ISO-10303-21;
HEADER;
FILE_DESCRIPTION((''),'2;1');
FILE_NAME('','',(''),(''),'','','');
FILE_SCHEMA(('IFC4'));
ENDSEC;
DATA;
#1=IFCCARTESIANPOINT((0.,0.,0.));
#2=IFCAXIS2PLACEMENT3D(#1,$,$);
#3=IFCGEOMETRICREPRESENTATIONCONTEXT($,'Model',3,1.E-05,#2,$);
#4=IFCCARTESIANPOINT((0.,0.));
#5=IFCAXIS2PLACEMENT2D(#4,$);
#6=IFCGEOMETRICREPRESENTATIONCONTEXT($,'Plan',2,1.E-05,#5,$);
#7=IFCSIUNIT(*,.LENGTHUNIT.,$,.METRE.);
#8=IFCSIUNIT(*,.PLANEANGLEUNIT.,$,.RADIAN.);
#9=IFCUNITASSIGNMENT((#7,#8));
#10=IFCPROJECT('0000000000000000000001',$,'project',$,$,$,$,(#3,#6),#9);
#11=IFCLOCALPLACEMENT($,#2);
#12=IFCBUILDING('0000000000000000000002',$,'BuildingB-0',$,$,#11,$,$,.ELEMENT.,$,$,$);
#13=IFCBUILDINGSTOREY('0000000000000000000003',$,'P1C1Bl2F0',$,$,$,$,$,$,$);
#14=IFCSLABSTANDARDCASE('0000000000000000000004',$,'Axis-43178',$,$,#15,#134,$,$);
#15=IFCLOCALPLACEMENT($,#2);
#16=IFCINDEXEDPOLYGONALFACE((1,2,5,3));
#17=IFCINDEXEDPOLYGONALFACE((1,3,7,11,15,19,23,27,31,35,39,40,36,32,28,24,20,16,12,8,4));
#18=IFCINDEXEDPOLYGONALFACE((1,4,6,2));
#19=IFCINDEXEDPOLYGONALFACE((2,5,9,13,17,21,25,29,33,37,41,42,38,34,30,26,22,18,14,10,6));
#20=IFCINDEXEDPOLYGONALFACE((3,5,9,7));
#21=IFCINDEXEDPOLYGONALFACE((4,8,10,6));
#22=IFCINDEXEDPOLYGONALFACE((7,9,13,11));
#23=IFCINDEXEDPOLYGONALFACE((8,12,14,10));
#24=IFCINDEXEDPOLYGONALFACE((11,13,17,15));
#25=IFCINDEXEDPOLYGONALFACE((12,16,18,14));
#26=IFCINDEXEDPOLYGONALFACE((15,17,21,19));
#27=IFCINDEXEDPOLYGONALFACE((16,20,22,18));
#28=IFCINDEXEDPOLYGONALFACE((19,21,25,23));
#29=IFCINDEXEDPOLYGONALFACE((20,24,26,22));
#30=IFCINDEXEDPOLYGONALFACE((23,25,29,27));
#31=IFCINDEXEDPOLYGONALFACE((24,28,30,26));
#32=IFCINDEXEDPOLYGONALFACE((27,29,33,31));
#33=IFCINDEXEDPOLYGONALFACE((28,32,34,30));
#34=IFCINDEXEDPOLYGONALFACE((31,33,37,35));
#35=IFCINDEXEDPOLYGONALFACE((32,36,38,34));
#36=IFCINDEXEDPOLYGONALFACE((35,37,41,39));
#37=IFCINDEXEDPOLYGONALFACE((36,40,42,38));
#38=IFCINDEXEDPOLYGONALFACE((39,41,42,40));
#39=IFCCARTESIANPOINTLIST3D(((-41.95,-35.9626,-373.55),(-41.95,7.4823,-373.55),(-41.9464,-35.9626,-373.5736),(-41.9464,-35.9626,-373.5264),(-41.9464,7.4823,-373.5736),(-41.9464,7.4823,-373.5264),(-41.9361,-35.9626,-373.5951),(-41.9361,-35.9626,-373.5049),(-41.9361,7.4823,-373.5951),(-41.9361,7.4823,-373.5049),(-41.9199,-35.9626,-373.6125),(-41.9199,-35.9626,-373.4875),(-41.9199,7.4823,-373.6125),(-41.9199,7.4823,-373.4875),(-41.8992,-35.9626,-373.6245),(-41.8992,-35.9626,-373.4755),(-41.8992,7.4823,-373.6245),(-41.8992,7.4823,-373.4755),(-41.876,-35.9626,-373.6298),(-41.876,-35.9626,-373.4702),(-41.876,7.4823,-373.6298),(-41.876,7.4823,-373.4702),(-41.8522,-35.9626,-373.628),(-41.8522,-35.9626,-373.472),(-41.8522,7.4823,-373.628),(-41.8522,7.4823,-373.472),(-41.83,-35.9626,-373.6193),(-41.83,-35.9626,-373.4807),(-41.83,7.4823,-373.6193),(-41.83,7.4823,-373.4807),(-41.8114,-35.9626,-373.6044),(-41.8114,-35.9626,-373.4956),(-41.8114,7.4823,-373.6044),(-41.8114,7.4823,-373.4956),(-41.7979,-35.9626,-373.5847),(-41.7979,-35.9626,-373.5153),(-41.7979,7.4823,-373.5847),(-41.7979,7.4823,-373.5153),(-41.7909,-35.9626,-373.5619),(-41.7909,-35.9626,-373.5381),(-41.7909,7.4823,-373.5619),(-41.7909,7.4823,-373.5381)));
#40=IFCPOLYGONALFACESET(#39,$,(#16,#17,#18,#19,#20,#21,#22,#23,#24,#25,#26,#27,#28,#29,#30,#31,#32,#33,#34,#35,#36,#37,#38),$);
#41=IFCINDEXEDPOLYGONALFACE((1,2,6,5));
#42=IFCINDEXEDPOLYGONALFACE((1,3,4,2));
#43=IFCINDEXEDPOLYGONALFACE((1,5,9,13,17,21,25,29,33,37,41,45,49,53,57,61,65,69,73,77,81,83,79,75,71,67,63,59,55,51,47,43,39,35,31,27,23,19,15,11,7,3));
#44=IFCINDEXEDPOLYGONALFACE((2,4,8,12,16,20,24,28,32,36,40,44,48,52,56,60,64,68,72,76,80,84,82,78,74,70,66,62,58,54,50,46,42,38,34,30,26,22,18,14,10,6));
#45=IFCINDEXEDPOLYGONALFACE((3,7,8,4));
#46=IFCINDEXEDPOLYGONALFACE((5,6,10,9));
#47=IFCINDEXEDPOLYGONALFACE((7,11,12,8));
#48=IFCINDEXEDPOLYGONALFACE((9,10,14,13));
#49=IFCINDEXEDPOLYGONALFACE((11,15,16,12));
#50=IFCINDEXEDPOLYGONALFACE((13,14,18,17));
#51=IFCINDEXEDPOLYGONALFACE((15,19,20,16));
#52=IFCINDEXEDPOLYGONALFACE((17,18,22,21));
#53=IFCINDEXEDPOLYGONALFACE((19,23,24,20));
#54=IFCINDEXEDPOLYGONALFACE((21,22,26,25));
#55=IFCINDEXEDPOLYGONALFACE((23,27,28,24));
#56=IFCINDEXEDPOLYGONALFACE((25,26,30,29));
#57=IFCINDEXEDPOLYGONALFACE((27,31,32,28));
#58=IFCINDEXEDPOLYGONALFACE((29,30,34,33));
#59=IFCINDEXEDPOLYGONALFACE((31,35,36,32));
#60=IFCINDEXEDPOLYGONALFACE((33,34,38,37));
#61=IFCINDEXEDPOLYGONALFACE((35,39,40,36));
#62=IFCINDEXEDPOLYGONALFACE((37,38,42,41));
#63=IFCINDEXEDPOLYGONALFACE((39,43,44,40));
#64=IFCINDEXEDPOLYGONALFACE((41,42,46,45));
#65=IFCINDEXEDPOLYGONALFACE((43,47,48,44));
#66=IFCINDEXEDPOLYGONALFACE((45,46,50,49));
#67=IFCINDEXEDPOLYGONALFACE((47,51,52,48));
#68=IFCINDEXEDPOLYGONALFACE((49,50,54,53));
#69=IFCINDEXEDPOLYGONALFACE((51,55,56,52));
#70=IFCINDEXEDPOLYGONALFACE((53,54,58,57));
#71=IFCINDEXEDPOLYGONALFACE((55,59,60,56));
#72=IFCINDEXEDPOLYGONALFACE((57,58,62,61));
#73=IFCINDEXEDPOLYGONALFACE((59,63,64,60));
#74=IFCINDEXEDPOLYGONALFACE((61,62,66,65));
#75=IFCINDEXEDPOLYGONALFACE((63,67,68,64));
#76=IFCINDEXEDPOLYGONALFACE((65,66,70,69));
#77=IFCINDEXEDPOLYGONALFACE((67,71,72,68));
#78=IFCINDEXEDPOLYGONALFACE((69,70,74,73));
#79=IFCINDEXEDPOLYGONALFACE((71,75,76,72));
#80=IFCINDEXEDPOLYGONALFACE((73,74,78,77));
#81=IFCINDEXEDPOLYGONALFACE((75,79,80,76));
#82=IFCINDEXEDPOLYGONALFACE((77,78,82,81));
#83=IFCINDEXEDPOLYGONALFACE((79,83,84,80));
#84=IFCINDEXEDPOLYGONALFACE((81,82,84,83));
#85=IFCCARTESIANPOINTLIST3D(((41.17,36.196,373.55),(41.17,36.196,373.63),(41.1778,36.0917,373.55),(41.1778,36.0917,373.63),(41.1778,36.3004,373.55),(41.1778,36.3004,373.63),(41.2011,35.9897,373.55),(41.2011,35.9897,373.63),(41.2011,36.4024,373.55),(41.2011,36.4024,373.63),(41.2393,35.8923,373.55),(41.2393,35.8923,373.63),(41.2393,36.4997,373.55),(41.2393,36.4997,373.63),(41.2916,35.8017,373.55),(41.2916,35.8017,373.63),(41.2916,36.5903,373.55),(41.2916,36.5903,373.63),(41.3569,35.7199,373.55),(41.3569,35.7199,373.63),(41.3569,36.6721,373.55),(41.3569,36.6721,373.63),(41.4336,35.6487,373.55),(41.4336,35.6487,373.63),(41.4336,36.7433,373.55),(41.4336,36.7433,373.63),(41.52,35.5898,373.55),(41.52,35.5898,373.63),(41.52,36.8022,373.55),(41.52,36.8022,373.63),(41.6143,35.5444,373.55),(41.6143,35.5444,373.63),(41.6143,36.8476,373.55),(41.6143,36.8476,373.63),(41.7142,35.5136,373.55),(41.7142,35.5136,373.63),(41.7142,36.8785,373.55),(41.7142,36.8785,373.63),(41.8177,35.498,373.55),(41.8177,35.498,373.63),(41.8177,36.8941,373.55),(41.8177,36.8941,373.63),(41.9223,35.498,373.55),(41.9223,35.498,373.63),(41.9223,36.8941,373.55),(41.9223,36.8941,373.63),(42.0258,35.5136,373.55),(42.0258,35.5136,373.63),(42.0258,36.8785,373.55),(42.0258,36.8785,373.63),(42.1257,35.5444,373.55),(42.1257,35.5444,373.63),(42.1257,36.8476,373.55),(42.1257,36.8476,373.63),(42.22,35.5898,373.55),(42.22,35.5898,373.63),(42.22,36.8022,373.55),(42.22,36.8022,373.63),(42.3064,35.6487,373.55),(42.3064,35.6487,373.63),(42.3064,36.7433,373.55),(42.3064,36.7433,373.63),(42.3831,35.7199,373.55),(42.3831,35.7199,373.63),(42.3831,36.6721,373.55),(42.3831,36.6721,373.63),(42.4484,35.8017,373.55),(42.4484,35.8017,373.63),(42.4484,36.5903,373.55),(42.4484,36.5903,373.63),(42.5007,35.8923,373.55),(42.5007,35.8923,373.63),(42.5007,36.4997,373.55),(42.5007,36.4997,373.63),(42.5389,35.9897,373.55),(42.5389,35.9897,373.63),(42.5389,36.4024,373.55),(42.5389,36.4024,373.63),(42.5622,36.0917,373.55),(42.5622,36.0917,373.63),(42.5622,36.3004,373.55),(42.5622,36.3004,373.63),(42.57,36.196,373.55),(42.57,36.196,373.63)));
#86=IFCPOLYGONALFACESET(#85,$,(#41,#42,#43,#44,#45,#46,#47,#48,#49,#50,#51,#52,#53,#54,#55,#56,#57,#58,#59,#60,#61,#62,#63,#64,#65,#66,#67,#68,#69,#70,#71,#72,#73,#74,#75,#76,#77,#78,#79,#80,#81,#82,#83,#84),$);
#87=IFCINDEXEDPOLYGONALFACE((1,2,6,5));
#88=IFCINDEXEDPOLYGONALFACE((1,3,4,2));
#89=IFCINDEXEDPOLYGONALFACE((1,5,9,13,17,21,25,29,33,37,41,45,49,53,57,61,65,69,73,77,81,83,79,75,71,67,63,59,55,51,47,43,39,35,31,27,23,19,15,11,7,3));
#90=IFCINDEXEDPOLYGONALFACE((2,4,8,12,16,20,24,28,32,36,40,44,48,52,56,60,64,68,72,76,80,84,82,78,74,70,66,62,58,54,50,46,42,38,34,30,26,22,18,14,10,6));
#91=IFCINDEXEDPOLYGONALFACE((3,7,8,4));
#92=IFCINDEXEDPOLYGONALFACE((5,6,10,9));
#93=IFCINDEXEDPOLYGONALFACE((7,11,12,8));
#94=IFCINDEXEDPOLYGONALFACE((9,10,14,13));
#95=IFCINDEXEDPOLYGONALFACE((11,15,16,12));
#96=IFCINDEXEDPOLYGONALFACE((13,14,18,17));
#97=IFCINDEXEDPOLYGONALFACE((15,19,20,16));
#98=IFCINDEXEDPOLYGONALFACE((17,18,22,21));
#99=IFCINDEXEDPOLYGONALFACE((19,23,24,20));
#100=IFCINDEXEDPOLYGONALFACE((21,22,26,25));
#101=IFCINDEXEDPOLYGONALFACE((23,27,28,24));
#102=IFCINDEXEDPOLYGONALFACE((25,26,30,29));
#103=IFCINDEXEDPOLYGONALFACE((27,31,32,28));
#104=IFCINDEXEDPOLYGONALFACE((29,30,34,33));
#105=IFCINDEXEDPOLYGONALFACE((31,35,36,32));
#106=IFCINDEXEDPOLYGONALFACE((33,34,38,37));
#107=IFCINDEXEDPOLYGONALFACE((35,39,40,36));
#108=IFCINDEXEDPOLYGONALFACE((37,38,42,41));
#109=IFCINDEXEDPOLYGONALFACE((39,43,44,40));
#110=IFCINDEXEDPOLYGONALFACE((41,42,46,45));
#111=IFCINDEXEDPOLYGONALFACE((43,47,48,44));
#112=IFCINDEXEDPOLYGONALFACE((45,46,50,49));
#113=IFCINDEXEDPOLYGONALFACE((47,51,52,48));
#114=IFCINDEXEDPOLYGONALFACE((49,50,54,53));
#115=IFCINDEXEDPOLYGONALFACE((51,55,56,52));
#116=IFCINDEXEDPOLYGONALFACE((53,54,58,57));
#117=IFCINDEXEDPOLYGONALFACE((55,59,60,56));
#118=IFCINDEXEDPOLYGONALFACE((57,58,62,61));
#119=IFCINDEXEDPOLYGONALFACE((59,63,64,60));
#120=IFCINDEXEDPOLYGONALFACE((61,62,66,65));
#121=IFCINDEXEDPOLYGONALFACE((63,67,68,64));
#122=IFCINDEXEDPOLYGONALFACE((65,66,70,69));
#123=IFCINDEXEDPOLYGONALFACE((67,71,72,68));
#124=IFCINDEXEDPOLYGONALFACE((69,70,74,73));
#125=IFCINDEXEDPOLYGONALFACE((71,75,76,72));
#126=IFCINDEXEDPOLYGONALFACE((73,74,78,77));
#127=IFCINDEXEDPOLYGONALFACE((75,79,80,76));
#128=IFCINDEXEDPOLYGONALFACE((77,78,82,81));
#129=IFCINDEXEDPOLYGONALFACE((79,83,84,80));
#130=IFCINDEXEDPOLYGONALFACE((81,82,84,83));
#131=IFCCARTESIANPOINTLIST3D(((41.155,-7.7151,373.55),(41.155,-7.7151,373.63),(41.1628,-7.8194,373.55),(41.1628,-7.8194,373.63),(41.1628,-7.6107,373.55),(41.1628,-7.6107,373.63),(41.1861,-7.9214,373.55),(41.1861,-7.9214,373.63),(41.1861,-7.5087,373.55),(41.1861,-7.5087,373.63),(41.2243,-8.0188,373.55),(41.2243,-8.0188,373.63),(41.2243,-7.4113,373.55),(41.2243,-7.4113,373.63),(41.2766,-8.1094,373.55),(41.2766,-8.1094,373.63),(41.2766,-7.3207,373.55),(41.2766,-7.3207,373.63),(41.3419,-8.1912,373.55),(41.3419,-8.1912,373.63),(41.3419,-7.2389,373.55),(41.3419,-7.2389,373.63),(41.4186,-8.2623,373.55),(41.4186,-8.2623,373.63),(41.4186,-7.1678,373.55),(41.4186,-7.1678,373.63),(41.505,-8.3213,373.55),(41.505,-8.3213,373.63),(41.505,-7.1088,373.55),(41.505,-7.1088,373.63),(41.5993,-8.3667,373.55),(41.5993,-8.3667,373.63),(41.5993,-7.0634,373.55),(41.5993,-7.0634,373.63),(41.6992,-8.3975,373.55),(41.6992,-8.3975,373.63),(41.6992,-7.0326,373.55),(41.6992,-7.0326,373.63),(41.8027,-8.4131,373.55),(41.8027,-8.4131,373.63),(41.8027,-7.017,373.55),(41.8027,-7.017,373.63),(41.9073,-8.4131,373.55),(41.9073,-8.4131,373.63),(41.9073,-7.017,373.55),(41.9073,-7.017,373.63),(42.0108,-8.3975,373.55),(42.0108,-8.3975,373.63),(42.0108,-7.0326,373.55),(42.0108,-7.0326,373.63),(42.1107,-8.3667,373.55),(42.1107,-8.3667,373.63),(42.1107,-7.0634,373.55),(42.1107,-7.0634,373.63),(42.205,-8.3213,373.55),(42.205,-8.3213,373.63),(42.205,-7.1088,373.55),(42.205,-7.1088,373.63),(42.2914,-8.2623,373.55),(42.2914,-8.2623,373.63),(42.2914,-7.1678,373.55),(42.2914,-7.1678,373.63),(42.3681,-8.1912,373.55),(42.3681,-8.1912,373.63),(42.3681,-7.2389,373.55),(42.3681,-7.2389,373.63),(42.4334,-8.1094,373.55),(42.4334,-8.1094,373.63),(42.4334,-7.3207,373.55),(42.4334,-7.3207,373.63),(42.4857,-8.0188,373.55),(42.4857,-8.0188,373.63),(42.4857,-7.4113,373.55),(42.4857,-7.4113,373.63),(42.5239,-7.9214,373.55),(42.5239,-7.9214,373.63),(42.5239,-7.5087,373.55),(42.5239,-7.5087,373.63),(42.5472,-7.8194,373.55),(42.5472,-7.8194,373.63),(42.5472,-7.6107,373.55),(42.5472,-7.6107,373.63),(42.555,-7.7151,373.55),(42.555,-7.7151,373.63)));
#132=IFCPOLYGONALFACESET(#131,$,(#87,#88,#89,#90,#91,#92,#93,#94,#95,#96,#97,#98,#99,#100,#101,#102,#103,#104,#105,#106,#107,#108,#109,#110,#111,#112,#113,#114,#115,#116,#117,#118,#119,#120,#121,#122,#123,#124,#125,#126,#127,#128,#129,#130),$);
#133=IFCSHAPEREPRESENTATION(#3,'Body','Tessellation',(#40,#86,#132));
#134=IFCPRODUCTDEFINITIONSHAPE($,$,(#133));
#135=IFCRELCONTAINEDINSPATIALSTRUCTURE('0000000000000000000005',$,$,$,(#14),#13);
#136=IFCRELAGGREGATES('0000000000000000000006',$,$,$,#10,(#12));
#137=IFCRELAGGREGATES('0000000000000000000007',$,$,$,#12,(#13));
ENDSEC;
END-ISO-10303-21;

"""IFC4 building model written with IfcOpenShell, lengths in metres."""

from ifc_helpers import new_model, entity, si_unit, frame, origin, origin_2d, place, context, project, spatial, circle, extrude, element, save


model = new_model("IFC4")

# Units and contexts
model_context = context("Model", 3, precision=1e-05, world=origin())
plan_context = context("Plan", 2, precision=1e-05, world=origin_2d())
ifc_project = project(units=[si_unit("LENGTHUNIT", "METRE"), si_unit("PLANEANGLEUNIT", "RADIAN")], contexts=[model_context, plan_context])

# Building, storey
building_placement = place(None, origin())
building = spatial("IfcBuilding", under=ifc_project, at=building_placement, Name="BuildingB-0", CompositionType="ELEMENT")
storey = spatial("IfcBuildingStorey", under=building, Name="P1C1Bl2F0")

# Slab
element("IfcSlabStandardCase", 1, inside=storey, Name="Axis-43178", context=model_context, shape_type="AdvancedSweptSolid", body=[
    entity("IfcSurfaceCurveSweptAreaSolid", entity("IfcCircleProfileDef", "AREA", None, None, 0.08), None, entity("IfcPolyline", [entity("IfcCartesianPoint", [41.87, 35.9626, 373.55]), entity("IfcCartesianPoint", [41.87, -7.4823, 373.55])]), None, None, entity("IfcPlane", entity("IfcAxis2Placement3D", entity("IfcCartesianPoint", [41.87, 35.9626, 373.55]), entity("IfcDirection", [0.0, 0.0, 1.0]), entity("IfcDirection", [1.0, 0.0, 0.0])))),
    extrude(circle(Radius=0.7), frame((41.87, 36.196, 373.55)), (0.0, 0.0, 1.0), 0.08),
    extrude(circle(Radius=0.7), frame((41.855, -7.7151, 373.55)), (0.0, 0.0, 1.0), 0.08),
])

save(model, "model.ifc")
